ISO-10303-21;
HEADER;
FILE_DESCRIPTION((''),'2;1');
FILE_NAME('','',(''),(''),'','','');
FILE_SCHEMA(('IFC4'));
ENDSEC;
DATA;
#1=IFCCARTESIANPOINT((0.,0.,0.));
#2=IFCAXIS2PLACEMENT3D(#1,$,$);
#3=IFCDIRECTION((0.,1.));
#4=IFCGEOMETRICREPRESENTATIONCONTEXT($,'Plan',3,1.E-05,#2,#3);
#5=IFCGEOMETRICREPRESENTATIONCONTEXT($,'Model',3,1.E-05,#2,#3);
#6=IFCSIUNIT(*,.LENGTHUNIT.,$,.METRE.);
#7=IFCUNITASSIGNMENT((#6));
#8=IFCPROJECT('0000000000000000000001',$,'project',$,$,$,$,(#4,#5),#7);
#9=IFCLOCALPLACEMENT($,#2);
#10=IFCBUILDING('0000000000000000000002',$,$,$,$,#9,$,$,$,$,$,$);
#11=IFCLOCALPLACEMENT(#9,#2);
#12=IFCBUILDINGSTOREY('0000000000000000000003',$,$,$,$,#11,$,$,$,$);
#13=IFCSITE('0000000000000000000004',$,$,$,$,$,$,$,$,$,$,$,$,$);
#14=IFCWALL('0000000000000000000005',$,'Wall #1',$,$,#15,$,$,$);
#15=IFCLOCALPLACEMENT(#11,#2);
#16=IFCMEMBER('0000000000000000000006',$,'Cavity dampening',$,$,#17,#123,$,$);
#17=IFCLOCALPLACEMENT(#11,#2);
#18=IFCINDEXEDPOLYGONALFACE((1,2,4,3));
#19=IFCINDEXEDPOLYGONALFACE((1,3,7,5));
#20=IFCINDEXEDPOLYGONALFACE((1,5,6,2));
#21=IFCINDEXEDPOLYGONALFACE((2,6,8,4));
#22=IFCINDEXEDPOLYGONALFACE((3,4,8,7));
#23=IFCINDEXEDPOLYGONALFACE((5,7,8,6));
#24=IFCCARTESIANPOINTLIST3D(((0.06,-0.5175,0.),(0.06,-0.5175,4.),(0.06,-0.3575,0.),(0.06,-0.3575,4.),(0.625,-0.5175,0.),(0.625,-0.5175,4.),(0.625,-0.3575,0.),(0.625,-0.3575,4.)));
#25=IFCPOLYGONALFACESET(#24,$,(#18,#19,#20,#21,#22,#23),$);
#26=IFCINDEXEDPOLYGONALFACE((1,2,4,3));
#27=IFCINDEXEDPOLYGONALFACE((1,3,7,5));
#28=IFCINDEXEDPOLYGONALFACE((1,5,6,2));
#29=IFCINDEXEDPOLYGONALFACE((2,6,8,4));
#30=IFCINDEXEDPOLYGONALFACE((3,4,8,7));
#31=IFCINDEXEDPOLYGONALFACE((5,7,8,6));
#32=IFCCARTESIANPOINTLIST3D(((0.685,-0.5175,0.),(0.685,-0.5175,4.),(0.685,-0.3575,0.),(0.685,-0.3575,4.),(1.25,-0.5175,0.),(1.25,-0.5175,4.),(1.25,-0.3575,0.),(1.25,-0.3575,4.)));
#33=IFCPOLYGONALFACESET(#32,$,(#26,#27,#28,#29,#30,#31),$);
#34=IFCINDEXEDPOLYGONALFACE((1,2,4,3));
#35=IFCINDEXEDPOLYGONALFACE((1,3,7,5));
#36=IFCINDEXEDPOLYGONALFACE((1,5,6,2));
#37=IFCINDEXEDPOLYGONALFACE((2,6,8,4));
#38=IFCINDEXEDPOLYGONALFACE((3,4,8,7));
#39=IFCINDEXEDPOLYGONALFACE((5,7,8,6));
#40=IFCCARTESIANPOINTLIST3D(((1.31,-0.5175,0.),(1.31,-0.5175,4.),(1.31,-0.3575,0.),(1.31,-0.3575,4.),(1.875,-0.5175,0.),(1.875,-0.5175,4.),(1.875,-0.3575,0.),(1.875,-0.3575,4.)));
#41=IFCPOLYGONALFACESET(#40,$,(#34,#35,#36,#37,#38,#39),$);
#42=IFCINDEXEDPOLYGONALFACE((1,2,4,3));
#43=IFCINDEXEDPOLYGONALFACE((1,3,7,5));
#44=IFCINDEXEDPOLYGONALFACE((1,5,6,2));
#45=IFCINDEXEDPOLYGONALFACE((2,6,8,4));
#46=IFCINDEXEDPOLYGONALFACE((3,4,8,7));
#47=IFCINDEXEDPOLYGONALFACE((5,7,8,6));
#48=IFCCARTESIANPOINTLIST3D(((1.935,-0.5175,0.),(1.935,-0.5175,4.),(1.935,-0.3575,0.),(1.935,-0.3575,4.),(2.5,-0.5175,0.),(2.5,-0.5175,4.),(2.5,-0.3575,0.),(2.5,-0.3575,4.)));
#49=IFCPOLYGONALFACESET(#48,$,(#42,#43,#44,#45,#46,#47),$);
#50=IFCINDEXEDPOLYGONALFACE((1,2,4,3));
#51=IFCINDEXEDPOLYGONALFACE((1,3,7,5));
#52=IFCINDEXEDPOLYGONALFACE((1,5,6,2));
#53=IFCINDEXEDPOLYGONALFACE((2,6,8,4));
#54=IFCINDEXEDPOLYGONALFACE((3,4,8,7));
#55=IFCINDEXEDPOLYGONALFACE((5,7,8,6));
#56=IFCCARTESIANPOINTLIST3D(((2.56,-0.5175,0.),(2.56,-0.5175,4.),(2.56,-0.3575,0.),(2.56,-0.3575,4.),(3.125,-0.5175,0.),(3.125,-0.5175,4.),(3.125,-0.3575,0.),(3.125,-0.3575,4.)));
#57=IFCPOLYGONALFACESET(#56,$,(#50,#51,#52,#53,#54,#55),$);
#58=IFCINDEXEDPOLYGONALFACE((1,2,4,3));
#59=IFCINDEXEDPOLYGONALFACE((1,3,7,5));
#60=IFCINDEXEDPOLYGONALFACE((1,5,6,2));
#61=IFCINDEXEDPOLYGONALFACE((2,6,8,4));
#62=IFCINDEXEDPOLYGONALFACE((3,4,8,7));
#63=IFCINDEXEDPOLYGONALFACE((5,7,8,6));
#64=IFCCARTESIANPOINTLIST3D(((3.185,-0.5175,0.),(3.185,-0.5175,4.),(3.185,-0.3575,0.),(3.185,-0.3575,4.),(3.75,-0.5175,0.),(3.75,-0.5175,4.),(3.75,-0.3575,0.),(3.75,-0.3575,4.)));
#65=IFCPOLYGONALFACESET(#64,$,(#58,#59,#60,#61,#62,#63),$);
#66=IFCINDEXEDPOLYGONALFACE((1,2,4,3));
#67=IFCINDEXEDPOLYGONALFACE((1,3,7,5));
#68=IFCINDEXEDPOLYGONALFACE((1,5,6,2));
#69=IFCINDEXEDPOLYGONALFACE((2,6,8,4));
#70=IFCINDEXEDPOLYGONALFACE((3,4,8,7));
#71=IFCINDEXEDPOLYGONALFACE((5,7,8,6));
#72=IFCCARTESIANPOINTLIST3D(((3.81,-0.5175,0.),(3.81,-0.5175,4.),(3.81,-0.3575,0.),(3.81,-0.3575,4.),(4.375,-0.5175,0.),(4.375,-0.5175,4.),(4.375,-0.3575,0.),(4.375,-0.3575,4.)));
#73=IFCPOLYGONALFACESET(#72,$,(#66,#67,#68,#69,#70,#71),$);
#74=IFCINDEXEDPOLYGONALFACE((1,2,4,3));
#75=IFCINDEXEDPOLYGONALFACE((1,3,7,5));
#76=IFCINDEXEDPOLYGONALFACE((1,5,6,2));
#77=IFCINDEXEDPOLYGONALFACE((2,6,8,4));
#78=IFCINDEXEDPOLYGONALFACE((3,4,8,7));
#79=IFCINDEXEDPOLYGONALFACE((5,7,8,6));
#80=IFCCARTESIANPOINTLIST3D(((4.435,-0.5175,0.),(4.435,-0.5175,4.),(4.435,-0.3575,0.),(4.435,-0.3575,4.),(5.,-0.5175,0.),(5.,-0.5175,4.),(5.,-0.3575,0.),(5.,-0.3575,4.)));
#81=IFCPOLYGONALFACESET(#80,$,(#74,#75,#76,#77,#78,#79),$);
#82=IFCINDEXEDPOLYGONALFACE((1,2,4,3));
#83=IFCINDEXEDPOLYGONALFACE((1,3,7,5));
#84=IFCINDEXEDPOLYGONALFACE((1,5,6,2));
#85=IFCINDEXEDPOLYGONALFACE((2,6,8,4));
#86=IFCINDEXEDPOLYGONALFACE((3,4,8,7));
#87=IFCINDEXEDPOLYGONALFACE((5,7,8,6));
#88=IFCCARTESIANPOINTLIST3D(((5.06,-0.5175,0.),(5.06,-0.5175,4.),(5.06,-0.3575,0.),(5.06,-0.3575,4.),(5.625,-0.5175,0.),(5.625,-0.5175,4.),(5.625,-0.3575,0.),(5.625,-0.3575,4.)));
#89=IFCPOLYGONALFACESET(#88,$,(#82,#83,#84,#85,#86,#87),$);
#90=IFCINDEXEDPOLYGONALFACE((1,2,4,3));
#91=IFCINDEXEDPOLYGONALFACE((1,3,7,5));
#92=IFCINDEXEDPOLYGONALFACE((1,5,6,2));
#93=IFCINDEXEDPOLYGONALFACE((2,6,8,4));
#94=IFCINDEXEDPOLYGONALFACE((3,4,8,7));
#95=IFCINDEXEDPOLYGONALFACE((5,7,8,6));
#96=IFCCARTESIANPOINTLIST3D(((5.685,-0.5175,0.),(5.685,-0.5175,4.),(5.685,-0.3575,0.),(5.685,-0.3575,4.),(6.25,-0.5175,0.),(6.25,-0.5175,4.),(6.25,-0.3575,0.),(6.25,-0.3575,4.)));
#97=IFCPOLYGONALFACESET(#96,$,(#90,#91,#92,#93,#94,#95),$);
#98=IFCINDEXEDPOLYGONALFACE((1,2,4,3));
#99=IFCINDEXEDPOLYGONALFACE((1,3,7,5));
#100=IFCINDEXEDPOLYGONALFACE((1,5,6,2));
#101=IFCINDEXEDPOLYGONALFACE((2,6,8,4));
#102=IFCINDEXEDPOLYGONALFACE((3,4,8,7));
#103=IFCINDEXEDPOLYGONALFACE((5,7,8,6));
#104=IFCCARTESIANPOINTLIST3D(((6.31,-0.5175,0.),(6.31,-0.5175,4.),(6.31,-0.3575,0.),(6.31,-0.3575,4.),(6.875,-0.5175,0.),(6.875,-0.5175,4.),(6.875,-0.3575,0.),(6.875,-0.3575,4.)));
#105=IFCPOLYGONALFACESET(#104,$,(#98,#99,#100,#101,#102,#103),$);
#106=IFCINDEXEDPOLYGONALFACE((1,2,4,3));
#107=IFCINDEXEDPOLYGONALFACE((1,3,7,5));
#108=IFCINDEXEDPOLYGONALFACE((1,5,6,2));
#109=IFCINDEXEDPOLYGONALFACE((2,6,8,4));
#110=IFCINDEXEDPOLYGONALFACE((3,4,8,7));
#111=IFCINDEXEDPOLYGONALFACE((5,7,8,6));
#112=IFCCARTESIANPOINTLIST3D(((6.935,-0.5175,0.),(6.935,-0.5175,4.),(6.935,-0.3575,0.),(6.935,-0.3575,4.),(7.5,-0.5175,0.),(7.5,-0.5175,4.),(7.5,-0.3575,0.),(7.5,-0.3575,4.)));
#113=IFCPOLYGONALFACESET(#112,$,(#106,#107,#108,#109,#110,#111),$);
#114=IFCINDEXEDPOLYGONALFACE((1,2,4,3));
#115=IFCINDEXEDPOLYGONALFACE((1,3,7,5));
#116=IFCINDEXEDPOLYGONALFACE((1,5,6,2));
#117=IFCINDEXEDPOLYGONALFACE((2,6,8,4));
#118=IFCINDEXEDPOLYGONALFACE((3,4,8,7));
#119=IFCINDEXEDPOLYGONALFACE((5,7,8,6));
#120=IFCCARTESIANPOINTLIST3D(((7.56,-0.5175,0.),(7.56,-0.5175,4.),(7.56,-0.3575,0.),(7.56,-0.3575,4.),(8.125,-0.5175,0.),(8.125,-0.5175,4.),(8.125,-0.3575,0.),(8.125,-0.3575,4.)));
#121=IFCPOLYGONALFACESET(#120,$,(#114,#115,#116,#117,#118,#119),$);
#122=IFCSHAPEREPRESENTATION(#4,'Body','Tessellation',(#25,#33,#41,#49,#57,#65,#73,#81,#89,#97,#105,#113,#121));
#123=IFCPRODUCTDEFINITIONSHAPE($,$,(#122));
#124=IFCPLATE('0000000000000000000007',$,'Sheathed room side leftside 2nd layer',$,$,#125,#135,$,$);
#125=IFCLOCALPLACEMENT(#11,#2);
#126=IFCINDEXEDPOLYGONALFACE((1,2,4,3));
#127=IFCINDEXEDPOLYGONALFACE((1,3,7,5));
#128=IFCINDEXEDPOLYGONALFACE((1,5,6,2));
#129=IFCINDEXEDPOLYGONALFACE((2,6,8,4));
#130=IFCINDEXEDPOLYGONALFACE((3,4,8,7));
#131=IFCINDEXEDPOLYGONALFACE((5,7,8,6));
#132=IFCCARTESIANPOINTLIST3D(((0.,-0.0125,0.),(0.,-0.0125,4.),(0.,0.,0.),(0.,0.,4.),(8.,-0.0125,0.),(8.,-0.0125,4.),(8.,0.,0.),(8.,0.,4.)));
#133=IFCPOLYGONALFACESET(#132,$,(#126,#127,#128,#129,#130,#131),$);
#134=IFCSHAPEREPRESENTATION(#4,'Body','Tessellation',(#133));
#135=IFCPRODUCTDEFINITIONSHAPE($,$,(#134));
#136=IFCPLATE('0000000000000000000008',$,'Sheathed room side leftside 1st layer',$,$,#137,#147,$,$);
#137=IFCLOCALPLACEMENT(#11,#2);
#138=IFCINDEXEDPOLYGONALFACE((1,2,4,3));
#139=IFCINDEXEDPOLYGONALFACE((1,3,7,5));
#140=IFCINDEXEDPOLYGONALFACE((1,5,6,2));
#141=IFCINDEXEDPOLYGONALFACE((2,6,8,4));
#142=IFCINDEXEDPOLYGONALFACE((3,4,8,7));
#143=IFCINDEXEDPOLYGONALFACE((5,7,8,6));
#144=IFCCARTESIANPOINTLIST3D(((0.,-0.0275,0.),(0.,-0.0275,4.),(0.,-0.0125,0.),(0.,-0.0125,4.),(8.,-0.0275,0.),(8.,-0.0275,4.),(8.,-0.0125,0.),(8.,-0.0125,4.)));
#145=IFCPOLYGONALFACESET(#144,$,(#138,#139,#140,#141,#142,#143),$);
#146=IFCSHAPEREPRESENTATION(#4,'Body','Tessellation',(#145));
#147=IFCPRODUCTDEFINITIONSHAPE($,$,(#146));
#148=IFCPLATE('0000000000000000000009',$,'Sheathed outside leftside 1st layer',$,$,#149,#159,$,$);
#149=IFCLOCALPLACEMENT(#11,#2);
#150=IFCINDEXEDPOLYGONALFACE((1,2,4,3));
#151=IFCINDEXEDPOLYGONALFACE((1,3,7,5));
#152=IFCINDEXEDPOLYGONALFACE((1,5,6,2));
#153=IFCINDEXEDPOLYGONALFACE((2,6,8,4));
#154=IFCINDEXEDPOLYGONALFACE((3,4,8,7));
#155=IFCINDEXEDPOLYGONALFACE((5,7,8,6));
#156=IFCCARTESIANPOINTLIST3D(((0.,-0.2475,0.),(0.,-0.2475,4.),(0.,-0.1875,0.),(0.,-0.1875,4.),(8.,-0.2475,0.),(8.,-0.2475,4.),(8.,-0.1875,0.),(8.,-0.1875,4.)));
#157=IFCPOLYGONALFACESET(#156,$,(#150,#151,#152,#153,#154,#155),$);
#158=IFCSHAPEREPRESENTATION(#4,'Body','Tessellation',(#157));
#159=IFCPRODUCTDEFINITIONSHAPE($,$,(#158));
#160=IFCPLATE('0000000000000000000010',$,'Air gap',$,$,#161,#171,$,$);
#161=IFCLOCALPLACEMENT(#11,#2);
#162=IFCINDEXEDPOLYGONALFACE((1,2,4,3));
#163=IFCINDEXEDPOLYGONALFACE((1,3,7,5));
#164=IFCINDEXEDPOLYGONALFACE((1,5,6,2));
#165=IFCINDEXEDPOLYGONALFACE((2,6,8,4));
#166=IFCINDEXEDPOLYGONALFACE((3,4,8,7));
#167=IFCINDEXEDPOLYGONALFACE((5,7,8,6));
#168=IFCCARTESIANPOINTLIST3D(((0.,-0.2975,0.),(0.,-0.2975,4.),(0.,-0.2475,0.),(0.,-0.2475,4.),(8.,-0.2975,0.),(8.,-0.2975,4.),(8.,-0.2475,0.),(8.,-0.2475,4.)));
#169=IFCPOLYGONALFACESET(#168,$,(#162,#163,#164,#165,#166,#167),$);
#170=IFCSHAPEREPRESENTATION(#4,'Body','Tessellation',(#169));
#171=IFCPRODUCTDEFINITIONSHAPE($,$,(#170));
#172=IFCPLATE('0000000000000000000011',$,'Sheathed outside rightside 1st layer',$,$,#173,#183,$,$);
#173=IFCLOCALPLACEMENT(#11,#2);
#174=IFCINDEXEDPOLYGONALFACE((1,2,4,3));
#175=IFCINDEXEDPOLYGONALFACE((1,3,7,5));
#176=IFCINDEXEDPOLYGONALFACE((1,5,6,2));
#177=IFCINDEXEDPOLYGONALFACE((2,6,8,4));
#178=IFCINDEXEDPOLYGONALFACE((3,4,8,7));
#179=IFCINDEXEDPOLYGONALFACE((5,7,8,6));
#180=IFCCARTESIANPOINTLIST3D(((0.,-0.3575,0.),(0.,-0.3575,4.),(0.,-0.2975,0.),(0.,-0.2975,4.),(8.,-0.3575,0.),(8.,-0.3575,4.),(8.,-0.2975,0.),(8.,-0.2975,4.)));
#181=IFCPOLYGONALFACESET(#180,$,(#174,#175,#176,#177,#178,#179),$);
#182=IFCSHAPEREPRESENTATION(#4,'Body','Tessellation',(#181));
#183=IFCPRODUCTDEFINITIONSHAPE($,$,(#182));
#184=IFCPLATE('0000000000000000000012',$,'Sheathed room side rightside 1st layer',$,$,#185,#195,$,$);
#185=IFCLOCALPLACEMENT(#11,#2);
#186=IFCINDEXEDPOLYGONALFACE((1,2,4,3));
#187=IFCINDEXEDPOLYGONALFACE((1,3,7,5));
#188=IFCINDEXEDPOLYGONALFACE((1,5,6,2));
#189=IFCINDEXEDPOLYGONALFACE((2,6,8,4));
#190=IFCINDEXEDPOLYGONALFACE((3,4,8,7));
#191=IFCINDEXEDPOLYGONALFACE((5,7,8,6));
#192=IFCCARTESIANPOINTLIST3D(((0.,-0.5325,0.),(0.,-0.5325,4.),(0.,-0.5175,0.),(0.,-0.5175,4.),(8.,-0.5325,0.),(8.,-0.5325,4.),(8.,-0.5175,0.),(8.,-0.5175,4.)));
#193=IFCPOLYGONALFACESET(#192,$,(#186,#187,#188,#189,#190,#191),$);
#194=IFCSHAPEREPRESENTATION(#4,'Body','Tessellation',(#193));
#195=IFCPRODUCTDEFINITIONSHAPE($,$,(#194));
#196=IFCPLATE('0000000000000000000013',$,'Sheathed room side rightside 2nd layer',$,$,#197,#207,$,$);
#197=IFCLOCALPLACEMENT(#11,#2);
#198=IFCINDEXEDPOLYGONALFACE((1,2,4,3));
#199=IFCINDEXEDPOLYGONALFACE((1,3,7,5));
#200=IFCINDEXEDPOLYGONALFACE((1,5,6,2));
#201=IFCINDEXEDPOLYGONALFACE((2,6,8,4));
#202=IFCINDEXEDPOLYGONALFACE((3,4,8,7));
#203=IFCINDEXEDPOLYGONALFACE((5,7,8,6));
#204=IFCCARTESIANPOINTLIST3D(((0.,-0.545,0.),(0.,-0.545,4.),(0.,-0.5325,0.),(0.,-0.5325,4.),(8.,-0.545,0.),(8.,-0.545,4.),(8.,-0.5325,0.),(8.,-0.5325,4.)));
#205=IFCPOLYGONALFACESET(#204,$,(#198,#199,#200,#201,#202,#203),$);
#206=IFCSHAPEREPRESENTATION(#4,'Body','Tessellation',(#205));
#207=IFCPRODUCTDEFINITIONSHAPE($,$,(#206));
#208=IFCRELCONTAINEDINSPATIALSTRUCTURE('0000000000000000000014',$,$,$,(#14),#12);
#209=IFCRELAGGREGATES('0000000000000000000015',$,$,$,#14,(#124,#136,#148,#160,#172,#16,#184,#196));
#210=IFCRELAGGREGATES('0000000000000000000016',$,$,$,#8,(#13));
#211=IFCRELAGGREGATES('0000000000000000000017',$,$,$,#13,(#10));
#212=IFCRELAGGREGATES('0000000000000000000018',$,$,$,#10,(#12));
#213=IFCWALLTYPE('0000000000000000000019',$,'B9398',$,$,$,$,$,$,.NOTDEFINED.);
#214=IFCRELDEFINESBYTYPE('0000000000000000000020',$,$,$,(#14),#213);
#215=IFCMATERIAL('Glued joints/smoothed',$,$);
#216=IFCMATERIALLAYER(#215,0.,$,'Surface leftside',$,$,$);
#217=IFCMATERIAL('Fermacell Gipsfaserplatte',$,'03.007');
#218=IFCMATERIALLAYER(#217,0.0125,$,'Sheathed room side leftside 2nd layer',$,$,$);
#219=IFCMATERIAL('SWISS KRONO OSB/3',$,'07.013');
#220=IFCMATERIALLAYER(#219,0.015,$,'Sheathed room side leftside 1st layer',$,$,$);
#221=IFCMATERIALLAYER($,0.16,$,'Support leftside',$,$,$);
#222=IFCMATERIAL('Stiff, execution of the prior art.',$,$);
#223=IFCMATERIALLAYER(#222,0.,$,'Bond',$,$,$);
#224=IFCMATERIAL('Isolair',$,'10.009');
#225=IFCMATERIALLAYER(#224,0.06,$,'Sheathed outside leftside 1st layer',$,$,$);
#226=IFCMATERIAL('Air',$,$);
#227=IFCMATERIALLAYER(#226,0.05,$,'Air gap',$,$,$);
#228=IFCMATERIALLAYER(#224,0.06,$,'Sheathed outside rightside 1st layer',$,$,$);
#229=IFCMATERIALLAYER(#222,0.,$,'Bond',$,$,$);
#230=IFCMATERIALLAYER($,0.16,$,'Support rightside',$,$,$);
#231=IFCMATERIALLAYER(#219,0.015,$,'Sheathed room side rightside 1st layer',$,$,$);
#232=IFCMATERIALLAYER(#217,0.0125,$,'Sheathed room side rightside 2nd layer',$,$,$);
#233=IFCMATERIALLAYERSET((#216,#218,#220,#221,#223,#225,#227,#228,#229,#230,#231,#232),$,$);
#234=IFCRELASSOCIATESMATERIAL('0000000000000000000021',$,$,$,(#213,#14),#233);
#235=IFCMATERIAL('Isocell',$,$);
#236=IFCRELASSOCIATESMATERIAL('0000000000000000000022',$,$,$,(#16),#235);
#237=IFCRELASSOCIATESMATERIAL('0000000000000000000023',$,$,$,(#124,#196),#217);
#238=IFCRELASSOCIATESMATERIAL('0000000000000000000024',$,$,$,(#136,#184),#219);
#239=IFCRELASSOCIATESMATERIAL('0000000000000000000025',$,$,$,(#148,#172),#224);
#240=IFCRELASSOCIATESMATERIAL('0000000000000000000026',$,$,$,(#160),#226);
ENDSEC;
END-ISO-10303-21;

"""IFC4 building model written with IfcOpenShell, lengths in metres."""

from ifc_helpers import new_model, si_unit, direction, frame, frame_2d, origin, origin_with_axes, place, context, project, spatial, rectangle, extrude, material, layer, layer_set, type_object, element, aggregate, save


model = new_model("IFC4")

# Units and contexts
plan_context = context("Plan", 3, precision=1e-05, world=origin(), true_north=direction((0.0, 1.0)))
model_context = context("Model", 3, precision=1e-05, world=origin(), true_north=direction((0.0, 1.0)))
ifc_project = project(units=[si_unit("LENGTHUNIT", "METRE")], contexts=[plan_context, model_context])

# Site, building, storey
site = spatial("IfcSite", under=ifc_project)
building_placement = place(None, origin())
building = spatial("IfcBuilding", under=site, at=building_placement)
storey_placement = place(building_placement, origin())
storey = spatial("IfcBuildingStorey", under=building, at=storey_placement)

# Wall, member, plates
ifc_material_1 = material(Name="Glued joints/smoothed")
ifc_layer_1 = layer(ifc_material_1, 0.0, Name="Surface leftside")
ifc_material_2 = material(Name="Fermacell Gipsfaserplatte", Category="03.007")
ifc_layer_2 = layer(ifc_material_2, 0.0125, Name="Sheathed room side leftside 2nd layer")
ifc_material_3 = material(Name="SWISS KRONO OSB/3", Category="07.013")
ifc_layer_3 = layer(ifc_material_3, 0.015, Name="Sheathed room side leftside 1st layer")
ifc_layer_4 = layer(None, 0.16, Name="Support leftside")
ifc_material_4 = material(Name="Stiff, execution of the prior art.")
ifc_layer_5 = layer(ifc_material_4, 0.0, Name="Bond")
ifc_material_5 = material(Name="Isolair", Category="10.009")
ifc_layer_6 = layer(ifc_material_5, 0.06, Name="Sheathed outside leftside 1st layer")
ifc_material_6 = material(Name="Air")
ifc_layer_7 = layer(ifc_material_6, 0.05, Name="Air gap")
ifc_layer_8 = layer(ifc_material_5, 0.06, Name="Sheathed outside rightside 1st layer")
ifc_layer_9 = layer(ifc_material_4, 0.0, Name="Bond")
ifc_layer_10 = layer(None, 0.16, Name="Support rightside")
ifc_layer_11 = layer(ifc_material_3, 0.015, Name="Sheathed room side rightside 1st layer")
ifc_layer_12 = layer(ifc_material_2, 0.0125, Name="Sheathed room side rightside 2nd layer")
ifc_layer_set = layer_set([ifc_layer_1, ifc_layer_2, ifc_layer_3, ifc_layer_4, ifc_layer_5, ifc_layer_6, ifc_layer_7, ifc_layer_8, ifc_layer_9, ifc_layer_10, ifc_layer_11, ifc_layer_12])
wall_type = type_object("IfcWallType", Name="B9398", PredefinedType="NOTDEFINED", material=ifc_layer_set)
wall_placement = place(None, frame((0.0, 0.0, 0.0), z_axis=(0.0, -1.0, 0.0), x_axis=(1.0, 0.0, 0.0)))
wall = element("IfcWall", 1, at=wall_placement, inside=storey, type_object=wall_type, material=ifc_layer_set, Name="Wall #1")
ifc_material_7 = material(Name="Isocell")
member_1_placement = place(wall_placement, origin())
member_1 = element("IfcMember", 2, at=member_1_placement, material=ifc_material_7, Name="Cavity dampening", context=plan_context, shape_type="SweptSolid", body=[
    extrude(rectangle(XDim=0.565, YDim=0.16, at=frame_2d((0.2825, 0.08), x_axis=(1.0, 0.0))), frame((0.06, 4.0, 0.3575), z_axis=(0.0, -1.0, 0.0), x_axis=(1.0, 0.0, 0.0)), (0.0, 0.0, 1.0), 4.0),
    extrude(rectangle(XDim=0.565, YDim=0.16, at=frame_2d((0.2825, 0.08), x_axis=(1.0, 0.0))), frame((0.685, 4.0, 0.3575), z_axis=(0.0, -1.0, 0.0), x_axis=(1.0, 0.0, 0.0)), (0.0, 0.0, 1.0), 4.0),
    extrude(rectangle(XDim=0.565, YDim=0.16, at=frame_2d((0.2825, 0.08), x_axis=(1.0, 0.0))), frame((1.31, 4.0, 0.3575), z_axis=(0.0, -1.0, 0.0), x_axis=(1.0, 0.0, 0.0)), (0.0, 0.0, 1.0), 4.0),
    extrude(rectangle(XDim=0.565, YDim=0.16, at=frame_2d((0.2825, 0.08), x_axis=(1.0, 0.0))), frame((1.935, 4.0, 0.3575), z_axis=(0.0, -1.0, 0.0), x_axis=(1.0, 0.0, 0.0)), (0.0, 0.0, 1.0), 4.0),
    extrude(rectangle(XDim=0.565, YDim=0.16, at=frame_2d((0.2825, 0.08), x_axis=(1.0, 0.0))), frame((2.56, 4.0, 0.3575), z_axis=(0.0, -1.0, 0.0), x_axis=(1.0, 0.0, 0.0)), (0.0, 0.0, 1.0), 4.0),
    extrude(rectangle(XDim=0.565, YDim=0.16, at=frame_2d((0.2825, 0.08), x_axis=(1.0, 0.0))), frame((3.185, 4.0, 0.3575), z_axis=(0.0, -1.0, 0.0), x_axis=(1.0, 0.0, 0.0)), (0.0, 0.0, 1.0), 4.0),
    extrude(rectangle(XDim=0.565, YDim=0.16, at=frame_2d((0.2825, 0.08), x_axis=(1.0, 0.0))), frame((3.81, 4.0, 0.3575), z_axis=(0.0, -1.0, 0.0), x_axis=(1.0, 0.0, 0.0)), (0.0, 0.0, 1.0), 4.0),
    extrude(rectangle(XDim=0.565, YDim=0.16, at=frame_2d((0.2825, 0.08), x_axis=(1.0, 0.0))), frame((4.435, 4.0, 0.3575), z_axis=(0.0, -1.0, 0.0), x_axis=(1.0, 0.0, 0.0)), (0.0, 0.0, 1.0), 4.0),
    extrude(rectangle(XDim=0.565, YDim=0.16, at=frame_2d((0.2825, 0.08), x_axis=(1.0, 0.0))), frame((5.06, 4.0, 0.3575), z_axis=(0.0, -1.0, 0.0), x_axis=(1.0, 0.0, 0.0)), (0.0, 0.0, 1.0), 4.0),
    extrude(rectangle(XDim=0.565, YDim=0.16, at=frame_2d((0.2825, 0.08), x_axis=(1.0, 0.0))), frame((5.685, 4.0, 0.3575), z_axis=(0.0, -1.0, 0.0), x_axis=(1.0, 0.0, 0.0)), (0.0, 0.0, 1.0), 4.0),
    extrude(rectangle(XDim=0.565, YDim=0.16, at=frame_2d((0.2825, 0.08), x_axis=(1.0, 0.0))), frame((6.31, 4.0, 0.3575), z_axis=(0.0, -1.0, 0.0), x_axis=(1.0, 0.0, 0.0)), (0.0, 0.0, 1.0), 4.0),
    extrude(rectangle(XDim=0.565, YDim=0.16, at=frame_2d((0.2825, 0.08), x_axis=(1.0, 0.0))), frame((6.935, 4.0, 0.3575), z_axis=(0.0, -1.0, 0.0), x_axis=(1.0, 0.0, 0.0)), (0.0, 0.0, 1.0), 4.0),
    extrude(rectangle(XDim=0.565, YDim=0.16, at=frame_2d((0.2825, 0.08), x_axis=(1.0, 0.0))), frame((7.56, 4.0, 0.3575), z_axis=(0.0, -1.0, 0.0), x_axis=(1.0, 0.0, 0.0)), (0.0, 0.0, 1.0), 4.0),
])
plate_1_placement = place(wall_placement, origin())
plate_1 = element("IfcPlate", 3, at=plate_1_placement, material=ifc_material_2, Name="Sheathed room side leftside 2nd layer", context=plan_context, shape_type="SweptSolid", body=[
    extrude(rectangle(XDim=8.0, YDim=4.0, at=frame_2d((4.0, 2.0), x_axis=(1.0, 0.0))), origin_with_axes(), (0.0, 0.0, 1.0), 0.0125),
])
plate_2_placement = place(wall_placement, origin())
plate_2 = element("IfcPlate", 4, at=plate_2_placement, material=ifc_material_3, Name="Sheathed room side leftside 1st layer", context=plan_context, shape_type="SweptSolid", body=[
    extrude(rectangle(XDim=8.0, YDim=4.0, at=frame_2d((4.0, 2.0), x_axis=(1.0, 0.0))), frame((0.0, 0.0, 0.0125), z_axis=(0.0, 0.0, 1.0), x_axis=(1.0, 0.0, 0.0)), (0.0, 0.0, 1.0), 0.015),
])
plate_3_placement = place(wall_placement, origin())
plate_3 = element("IfcPlate", 5, at=plate_3_placement, material=ifc_material_5, Name="Sheathed outside leftside 1st layer", context=plan_context, shape_type="SweptSolid", body=[
    extrude(rectangle(XDim=8.0, YDim=4.0, at=frame_2d((4.0, 2.0), x_axis=(1.0, 0.0))), frame((0.0, 0.0, 0.1875), z_axis=(0.0, 0.0, 1.0), x_axis=(1.0, 0.0, 0.0)), (0.0, 0.0, 1.0), 0.06),
])
plate_4_placement = place(wall_placement, origin())
plate_4 = element("IfcPlate", 6, at=plate_4_placement, material=ifc_material_6, Name="Air gap", context=plan_context, shape_type="SweptSolid", body=[
    extrude(rectangle(XDim=8.0, YDim=4.0, at=frame_2d((4.0, 2.0), x_axis=(1.0, 0.0))), frame((0.0, 0.0, 0.2475), z_axis=(0.0, 0.0, 1.0), x_axis=(1.0, 0.0, 0.0)), (0.0, 0.0, 1.0), 0.05),
])
plate_5_placement = place(wall_placement, origin())
plate_5 = element("IfcPlate", 7, at=plate_5_placement, material=ifc_material_5, Name="Sheathed outside rightside 1st layer", context=plan_context, shape_type="SweptSolid", body=[
    extrude(rectangle(XDim=8.0, YDim=4.0, at=frame_2d((4.0, 2.0), x_axis=(1.0, 0.0))), frame((0.0, 0.0, 0.2975), z_axis=(0.0, 0.0, 1.0), x_axis=(1.0, 0.0, 0.0)), (0.0, 0.0, 1.0), 0.06),
])
plate_6_placement = place(wall_placement, origin())
plate_6 = element("IfcPlate", 8, at=plate_6_placement, material=ifc_material_3, Name="Sheathed room side rightside 1st layer", context=plan_context, shape_type="SweptSolid", body=[
    extrude(rectangle(XDim=8.0, YDim=4.0, at=frame_2d((4.0, 2.0), x_axis=(1.0, 0.0))), frame((0.0, 0.0, 0.5175), z_axis=(0.0, 0.0, 1.0), x_axis=(1.0, 0.0, 0.0)), (0.0, 0.0, 1.0), 0.015),
])
plate_7_placement = place(wall_placement, origin())
plate_7 = element("IfcPlate", 9, at=plate_7_placement, material=ifc_material_2, Name="Sheathed room side rightside 2nd layer", context=plan_context, shape_type="SweptSolid", body=[
    extrude(rectangle(XDim=8.0, YDim=4.0, at=frame_2d((4.0, 2.0), x_axis=(1.0, 0.0))), frame((0.0, 0.0, 0.5325), z_axis=(0.0, 0.0, 1.0), x_axis=(1.0, 0.0, 0.0)), (0.0, 0.0, 1.0), 0.0125),
])
aggregate(wall, [plate_1, plate_2, plate_3, plate_4, plate_5, member_1, plate_6, plate_7])

save(model, "model.ifc")
